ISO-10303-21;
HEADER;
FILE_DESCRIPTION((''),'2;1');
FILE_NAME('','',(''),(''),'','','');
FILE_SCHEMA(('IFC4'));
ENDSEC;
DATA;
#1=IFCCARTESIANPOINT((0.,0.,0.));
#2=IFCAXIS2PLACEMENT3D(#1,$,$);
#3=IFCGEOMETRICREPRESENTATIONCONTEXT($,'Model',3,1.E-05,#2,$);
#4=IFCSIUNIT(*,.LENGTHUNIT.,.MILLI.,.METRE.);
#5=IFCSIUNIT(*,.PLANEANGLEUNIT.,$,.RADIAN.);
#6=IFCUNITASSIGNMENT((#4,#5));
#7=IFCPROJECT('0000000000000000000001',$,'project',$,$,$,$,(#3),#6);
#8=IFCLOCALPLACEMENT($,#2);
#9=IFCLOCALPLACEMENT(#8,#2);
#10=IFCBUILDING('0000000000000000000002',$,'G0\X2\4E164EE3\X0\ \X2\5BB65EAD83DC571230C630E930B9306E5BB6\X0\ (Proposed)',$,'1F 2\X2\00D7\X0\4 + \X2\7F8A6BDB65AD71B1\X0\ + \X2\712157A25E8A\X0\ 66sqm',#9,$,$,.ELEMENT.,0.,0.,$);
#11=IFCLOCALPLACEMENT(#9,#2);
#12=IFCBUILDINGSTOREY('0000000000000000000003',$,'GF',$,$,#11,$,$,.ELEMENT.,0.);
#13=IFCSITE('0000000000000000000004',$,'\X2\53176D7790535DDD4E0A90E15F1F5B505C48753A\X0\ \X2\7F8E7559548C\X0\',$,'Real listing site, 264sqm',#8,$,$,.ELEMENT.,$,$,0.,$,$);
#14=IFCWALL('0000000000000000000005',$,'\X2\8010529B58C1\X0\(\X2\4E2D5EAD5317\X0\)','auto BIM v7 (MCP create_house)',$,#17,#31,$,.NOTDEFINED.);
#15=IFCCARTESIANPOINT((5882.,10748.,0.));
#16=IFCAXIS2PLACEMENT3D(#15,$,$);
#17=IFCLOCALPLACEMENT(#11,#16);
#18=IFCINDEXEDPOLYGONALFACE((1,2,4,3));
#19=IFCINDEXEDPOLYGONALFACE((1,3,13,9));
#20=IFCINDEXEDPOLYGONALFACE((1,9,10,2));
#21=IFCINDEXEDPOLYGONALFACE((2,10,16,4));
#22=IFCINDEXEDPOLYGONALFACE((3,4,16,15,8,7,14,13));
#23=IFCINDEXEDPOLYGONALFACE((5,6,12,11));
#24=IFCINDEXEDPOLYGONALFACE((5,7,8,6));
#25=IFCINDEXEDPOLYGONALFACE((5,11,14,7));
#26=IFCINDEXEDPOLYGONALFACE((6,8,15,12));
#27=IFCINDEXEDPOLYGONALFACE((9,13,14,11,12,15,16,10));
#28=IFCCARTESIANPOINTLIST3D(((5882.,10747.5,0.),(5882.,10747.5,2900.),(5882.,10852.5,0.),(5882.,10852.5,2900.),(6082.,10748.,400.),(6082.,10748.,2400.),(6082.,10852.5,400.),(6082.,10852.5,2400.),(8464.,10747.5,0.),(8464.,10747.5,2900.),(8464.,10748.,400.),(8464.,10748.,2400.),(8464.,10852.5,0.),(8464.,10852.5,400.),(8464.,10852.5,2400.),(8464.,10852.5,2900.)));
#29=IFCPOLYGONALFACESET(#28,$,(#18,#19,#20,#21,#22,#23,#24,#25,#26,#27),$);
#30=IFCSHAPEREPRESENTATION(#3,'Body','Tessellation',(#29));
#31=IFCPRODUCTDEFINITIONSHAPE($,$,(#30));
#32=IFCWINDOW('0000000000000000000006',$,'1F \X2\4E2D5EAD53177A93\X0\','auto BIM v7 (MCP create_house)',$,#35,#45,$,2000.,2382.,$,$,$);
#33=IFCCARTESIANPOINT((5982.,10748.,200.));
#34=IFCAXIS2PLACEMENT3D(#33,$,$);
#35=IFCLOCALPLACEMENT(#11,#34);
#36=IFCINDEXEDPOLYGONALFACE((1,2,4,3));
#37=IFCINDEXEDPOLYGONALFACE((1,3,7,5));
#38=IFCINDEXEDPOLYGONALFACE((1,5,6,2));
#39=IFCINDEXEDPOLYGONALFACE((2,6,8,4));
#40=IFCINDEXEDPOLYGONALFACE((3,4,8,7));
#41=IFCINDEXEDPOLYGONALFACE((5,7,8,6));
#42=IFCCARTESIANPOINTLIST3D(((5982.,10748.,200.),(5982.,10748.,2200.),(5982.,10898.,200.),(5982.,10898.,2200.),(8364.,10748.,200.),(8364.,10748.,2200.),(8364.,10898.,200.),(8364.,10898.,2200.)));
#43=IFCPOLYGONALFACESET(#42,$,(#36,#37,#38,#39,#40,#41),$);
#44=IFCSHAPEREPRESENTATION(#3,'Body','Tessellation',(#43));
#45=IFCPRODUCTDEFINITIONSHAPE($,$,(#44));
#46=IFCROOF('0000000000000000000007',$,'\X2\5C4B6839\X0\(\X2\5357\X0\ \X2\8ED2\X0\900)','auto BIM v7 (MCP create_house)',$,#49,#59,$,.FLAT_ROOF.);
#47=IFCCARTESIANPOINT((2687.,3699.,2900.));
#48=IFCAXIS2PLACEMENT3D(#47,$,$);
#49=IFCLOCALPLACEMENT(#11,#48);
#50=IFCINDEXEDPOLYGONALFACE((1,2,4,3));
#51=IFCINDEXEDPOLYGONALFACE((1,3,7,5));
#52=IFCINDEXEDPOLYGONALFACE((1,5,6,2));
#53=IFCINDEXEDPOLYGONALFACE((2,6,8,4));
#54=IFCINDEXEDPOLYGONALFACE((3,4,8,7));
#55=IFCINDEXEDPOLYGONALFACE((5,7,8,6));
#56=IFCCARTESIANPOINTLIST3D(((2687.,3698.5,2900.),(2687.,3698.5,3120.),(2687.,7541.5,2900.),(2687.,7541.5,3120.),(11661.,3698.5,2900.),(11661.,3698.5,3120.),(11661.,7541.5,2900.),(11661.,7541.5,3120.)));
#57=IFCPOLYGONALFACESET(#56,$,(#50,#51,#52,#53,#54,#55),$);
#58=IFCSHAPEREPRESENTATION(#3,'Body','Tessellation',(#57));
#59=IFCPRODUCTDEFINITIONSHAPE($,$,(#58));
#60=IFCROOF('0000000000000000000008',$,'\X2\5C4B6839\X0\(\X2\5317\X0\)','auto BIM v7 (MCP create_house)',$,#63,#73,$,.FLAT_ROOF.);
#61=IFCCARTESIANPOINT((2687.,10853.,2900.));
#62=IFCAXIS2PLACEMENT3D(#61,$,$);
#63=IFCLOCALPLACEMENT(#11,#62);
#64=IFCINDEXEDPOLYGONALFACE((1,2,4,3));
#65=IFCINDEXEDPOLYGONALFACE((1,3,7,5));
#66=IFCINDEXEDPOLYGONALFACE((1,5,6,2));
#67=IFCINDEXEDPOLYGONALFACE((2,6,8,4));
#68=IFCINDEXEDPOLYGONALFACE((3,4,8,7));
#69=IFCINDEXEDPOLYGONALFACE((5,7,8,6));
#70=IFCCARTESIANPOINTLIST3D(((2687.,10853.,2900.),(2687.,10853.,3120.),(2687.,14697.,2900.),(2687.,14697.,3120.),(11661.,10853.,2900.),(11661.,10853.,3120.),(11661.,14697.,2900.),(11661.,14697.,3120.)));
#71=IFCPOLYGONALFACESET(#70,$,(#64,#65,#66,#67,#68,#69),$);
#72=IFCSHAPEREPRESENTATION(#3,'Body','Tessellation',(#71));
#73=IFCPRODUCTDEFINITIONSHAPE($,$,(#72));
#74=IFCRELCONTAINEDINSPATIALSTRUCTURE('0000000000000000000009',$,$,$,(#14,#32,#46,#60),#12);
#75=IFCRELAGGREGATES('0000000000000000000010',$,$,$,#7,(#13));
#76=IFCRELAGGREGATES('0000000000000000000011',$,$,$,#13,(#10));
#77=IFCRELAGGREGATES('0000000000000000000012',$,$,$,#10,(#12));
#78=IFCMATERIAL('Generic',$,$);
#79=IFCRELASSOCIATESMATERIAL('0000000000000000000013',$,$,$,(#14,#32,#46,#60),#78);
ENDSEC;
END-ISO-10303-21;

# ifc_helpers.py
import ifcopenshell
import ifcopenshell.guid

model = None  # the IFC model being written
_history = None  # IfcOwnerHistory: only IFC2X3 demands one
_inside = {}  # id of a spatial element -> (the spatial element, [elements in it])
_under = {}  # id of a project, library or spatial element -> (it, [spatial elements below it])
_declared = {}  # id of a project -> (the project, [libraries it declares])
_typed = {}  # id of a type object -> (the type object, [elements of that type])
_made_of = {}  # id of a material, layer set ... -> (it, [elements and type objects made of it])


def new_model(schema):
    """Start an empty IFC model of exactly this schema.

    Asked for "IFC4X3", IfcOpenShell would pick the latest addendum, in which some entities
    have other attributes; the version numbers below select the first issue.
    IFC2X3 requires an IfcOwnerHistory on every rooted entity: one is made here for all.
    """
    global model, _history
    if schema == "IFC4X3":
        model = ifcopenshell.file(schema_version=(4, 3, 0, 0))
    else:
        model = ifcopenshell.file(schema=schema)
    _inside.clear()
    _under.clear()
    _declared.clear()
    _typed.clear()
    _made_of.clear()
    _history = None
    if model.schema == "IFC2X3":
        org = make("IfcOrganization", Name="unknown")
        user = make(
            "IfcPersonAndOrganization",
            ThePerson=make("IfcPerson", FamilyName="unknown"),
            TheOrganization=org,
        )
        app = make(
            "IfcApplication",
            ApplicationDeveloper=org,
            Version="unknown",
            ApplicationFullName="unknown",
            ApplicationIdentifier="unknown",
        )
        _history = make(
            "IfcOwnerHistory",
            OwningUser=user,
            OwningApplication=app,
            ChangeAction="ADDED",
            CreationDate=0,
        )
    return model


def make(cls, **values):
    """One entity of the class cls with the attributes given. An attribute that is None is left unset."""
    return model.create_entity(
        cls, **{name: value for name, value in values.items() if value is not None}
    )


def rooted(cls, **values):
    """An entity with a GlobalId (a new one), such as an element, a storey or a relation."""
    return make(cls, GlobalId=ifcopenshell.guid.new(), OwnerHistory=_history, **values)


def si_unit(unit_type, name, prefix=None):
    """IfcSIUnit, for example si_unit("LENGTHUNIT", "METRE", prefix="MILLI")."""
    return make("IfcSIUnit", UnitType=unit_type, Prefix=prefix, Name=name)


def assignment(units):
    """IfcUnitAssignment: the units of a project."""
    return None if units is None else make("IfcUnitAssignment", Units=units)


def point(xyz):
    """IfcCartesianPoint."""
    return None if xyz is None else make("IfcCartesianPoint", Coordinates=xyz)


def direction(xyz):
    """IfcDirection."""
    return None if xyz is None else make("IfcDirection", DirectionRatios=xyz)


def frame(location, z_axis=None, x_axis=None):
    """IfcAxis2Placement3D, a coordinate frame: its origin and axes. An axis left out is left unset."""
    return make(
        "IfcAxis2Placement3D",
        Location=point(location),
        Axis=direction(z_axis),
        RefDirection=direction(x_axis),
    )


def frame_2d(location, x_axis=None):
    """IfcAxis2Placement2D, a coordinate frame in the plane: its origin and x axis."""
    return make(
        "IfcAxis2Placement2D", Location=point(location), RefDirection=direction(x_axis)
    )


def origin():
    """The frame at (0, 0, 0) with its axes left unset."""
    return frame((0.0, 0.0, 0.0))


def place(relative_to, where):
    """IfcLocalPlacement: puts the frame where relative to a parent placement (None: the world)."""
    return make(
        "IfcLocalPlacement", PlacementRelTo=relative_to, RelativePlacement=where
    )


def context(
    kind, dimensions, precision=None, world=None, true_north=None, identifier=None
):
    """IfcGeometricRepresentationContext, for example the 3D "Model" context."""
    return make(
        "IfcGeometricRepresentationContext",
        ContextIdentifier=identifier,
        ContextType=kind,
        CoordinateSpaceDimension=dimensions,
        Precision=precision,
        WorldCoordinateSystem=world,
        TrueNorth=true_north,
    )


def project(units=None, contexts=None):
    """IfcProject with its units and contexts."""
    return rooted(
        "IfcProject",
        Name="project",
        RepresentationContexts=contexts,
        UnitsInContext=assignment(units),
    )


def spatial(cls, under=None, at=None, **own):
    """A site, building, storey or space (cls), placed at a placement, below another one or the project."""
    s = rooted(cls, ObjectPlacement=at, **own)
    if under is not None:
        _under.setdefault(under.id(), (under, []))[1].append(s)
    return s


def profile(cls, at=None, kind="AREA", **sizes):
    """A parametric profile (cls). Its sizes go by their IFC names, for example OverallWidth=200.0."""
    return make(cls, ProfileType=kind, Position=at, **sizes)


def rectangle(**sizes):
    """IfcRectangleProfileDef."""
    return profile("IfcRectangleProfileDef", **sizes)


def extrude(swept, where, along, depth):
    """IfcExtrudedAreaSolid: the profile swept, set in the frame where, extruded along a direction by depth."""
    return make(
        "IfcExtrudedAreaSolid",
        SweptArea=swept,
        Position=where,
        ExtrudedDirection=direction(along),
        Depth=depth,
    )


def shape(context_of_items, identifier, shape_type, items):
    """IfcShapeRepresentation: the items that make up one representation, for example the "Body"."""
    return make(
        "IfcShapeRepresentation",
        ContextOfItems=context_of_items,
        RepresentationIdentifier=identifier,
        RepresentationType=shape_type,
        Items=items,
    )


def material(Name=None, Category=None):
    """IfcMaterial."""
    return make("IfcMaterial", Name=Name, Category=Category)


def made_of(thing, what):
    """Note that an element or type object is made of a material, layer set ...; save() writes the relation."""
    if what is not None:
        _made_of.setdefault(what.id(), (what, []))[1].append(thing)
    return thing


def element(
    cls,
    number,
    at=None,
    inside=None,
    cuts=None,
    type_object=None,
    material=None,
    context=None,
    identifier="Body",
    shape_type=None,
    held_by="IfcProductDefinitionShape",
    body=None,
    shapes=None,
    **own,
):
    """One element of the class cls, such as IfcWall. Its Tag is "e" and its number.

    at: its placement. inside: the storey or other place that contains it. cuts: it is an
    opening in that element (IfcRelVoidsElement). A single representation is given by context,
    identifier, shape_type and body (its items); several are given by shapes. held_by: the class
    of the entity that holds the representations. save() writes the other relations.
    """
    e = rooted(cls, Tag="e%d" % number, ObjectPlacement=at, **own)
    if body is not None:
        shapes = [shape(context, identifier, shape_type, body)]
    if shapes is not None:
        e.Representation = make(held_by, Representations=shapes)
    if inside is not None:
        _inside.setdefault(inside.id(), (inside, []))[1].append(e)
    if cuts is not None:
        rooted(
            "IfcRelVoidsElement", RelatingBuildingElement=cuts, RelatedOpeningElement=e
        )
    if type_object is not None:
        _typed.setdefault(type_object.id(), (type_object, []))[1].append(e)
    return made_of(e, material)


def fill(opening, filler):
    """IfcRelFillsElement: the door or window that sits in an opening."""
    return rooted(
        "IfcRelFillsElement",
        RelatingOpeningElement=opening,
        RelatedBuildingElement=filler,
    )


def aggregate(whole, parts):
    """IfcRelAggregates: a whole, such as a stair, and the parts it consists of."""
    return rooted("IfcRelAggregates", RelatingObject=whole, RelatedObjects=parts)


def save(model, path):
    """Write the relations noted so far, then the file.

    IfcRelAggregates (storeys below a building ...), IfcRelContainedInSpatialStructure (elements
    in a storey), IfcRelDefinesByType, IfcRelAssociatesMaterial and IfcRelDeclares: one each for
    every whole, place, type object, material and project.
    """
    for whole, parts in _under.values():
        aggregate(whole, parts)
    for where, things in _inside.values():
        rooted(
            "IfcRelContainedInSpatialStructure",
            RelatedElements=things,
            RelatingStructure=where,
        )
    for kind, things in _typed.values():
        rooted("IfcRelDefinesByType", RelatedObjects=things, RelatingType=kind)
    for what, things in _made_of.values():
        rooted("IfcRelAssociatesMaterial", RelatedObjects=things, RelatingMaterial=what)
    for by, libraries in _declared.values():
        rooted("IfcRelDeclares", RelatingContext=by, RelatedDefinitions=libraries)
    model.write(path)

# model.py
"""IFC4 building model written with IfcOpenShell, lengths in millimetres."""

from ifc_helpers import new_model, si_unit, frame, frame_2d, origin, place, context, project, spatial, rectangle, extrude, material, element, fill, save


model = new_model("IFC4")

# Units and contexts
model_context = context("Model", 3, precision=1e-05, world=origin())
ifc_project = project(units=[si_unit("LENGTHUNIT", "METRE", prefix="MILLI"), si_unit("PLANEANGLEUNIT", "RADIAN")], contexts=[model_context])

# Site, building, storey
site_placement = place(None, origin())
site = spatial("IfcSite", under=ifc_project, at=site_placement, Name="北海道川上郡弟子屈町 美留和", ObjectType="Real listing site, 264sqm", CompositionType="ELEMENT", RefElevation=0.0)
building_placement = place(site_placement, origin())
building = spatial("IfcBuilding", under=site, at=building_placement, Name="G0世代 家庭菜園テラスの家 (Proposed)", ObjectType="1F 2×4 + 羊毛断熱 + 無垢床 66sqm", CompositionType="ELEMENT", ElevationOfRefHeight=0.0, ElevationOfTerrain=0.0)
storey_placement = place(building_placement, origin())
storey = spatial("IfcBuildingStorey", under=building, at=storey_placement, Name="GF", CompositionType="ELEMENT", Elevation=0.0)

# Shared definitions
ifc_material = material(Name="Generic")

# Wall, opening, window
wall_1_placement = place(storey_placement, frame((5882.0, 10748.0, 0.0)))
wall_1 = element("IfcWall", 1, at=wall_1_placement, inside=storey, material=ifc_material, Name="耐力壁(中庭北)", Description="auto BIM v7 (MCP create_house)", PredefinedType="NOTDEFINED", context=model_context, shape_type="SweptSolid", body=[
    extrude(rectangle(XDim=2582.0, YDim=105.0, at=frame_2d((1291.0, 52.0))), frame((5882.0, 10748.0, 0.0)), (0.0, 0.0, 1.0), 2900.0),
])
opening_1_placement = place(storey_placement, frame((5982.0, 10748.0, 200.0)))
opening_1 = element("IfcOpeningElement", 2, at=opening_1_placement, cuts=wall_1, PredefinedType="NOTDEFINED", context=model_context, shape_type="SweptSolid", body=[
    extrude(rectangle(XDim=2382.0, YDim=150.0, at=frame_2d((1191.0, 75.0))), frame((5982.0, 10748.0, 200.0)), (0.0, 0.0, 1.0), 2000.0),
])
window_1_placement = place(storey_placement, frame((5982.0, 10748.0, 200.0)))
window_1 = element("IfcWindow", 3, at=window_1_placement, inside=storey, material=ifc_material, Name="1F 中庭北窓", Description="auto BIM v7 (MCP create_house)", OverallHeight=2000.0, OverallWidth=2382.0, context=model_context, shape_type="SweptSolid", body=[
    extrude(rectangle(XDim=2382.0, YDim=150.0, at=frame_2d((1191.0, 75.0))), frame((5982.0, 10748.0, 200.0)), (0.0, 0.0, 1.0), 2000.0),
])
fill(opening_1, window_1)

# Roofs
roof_1_placement = place(storey_placement, frame((2687.0, 3699.0, 2900.0)))
element("IfcRoof", 4, at=roof_1_placement, inside=storey, material=ifc_material, Name="屋根(南 軒900)", Description="auto BIM v7 (MCP create_house)", PredefinedType="FLAT_ROOF", context=model_context, shape_type="SweptSolid", body=[
    extrude(rectangle(XDim=8974.0, YDim=3843.0, at=frame_2d((4487.0, 1921.0))), frame((2687.0, 3699.0, 2900.0)), (0.0, 0.0, 1.0), 220.0),
])
roof_2_placement = place(storey_placement, frame((2687.0, 10853.0, 2900.0)))
element("IfcRoof", 5, at=roof_2_placement, inside=storey, material=ifc_material, Name="屋根(北)", Description="auto BIM v7 (MCP create_house)", PredefinedType="FLAT_ROOF", context=model_context, shape_type="SweptSolid", body=[
    extrude(rectangle(XDim=8974.0, YDim=3844.0, at=frame_2d((4487.0, 1922.0))), frame((2687.0, 10853.0, 2900.0)), (0.0, 0.0, 1.0), 220.0),
])

save(model, "model.ifc")
